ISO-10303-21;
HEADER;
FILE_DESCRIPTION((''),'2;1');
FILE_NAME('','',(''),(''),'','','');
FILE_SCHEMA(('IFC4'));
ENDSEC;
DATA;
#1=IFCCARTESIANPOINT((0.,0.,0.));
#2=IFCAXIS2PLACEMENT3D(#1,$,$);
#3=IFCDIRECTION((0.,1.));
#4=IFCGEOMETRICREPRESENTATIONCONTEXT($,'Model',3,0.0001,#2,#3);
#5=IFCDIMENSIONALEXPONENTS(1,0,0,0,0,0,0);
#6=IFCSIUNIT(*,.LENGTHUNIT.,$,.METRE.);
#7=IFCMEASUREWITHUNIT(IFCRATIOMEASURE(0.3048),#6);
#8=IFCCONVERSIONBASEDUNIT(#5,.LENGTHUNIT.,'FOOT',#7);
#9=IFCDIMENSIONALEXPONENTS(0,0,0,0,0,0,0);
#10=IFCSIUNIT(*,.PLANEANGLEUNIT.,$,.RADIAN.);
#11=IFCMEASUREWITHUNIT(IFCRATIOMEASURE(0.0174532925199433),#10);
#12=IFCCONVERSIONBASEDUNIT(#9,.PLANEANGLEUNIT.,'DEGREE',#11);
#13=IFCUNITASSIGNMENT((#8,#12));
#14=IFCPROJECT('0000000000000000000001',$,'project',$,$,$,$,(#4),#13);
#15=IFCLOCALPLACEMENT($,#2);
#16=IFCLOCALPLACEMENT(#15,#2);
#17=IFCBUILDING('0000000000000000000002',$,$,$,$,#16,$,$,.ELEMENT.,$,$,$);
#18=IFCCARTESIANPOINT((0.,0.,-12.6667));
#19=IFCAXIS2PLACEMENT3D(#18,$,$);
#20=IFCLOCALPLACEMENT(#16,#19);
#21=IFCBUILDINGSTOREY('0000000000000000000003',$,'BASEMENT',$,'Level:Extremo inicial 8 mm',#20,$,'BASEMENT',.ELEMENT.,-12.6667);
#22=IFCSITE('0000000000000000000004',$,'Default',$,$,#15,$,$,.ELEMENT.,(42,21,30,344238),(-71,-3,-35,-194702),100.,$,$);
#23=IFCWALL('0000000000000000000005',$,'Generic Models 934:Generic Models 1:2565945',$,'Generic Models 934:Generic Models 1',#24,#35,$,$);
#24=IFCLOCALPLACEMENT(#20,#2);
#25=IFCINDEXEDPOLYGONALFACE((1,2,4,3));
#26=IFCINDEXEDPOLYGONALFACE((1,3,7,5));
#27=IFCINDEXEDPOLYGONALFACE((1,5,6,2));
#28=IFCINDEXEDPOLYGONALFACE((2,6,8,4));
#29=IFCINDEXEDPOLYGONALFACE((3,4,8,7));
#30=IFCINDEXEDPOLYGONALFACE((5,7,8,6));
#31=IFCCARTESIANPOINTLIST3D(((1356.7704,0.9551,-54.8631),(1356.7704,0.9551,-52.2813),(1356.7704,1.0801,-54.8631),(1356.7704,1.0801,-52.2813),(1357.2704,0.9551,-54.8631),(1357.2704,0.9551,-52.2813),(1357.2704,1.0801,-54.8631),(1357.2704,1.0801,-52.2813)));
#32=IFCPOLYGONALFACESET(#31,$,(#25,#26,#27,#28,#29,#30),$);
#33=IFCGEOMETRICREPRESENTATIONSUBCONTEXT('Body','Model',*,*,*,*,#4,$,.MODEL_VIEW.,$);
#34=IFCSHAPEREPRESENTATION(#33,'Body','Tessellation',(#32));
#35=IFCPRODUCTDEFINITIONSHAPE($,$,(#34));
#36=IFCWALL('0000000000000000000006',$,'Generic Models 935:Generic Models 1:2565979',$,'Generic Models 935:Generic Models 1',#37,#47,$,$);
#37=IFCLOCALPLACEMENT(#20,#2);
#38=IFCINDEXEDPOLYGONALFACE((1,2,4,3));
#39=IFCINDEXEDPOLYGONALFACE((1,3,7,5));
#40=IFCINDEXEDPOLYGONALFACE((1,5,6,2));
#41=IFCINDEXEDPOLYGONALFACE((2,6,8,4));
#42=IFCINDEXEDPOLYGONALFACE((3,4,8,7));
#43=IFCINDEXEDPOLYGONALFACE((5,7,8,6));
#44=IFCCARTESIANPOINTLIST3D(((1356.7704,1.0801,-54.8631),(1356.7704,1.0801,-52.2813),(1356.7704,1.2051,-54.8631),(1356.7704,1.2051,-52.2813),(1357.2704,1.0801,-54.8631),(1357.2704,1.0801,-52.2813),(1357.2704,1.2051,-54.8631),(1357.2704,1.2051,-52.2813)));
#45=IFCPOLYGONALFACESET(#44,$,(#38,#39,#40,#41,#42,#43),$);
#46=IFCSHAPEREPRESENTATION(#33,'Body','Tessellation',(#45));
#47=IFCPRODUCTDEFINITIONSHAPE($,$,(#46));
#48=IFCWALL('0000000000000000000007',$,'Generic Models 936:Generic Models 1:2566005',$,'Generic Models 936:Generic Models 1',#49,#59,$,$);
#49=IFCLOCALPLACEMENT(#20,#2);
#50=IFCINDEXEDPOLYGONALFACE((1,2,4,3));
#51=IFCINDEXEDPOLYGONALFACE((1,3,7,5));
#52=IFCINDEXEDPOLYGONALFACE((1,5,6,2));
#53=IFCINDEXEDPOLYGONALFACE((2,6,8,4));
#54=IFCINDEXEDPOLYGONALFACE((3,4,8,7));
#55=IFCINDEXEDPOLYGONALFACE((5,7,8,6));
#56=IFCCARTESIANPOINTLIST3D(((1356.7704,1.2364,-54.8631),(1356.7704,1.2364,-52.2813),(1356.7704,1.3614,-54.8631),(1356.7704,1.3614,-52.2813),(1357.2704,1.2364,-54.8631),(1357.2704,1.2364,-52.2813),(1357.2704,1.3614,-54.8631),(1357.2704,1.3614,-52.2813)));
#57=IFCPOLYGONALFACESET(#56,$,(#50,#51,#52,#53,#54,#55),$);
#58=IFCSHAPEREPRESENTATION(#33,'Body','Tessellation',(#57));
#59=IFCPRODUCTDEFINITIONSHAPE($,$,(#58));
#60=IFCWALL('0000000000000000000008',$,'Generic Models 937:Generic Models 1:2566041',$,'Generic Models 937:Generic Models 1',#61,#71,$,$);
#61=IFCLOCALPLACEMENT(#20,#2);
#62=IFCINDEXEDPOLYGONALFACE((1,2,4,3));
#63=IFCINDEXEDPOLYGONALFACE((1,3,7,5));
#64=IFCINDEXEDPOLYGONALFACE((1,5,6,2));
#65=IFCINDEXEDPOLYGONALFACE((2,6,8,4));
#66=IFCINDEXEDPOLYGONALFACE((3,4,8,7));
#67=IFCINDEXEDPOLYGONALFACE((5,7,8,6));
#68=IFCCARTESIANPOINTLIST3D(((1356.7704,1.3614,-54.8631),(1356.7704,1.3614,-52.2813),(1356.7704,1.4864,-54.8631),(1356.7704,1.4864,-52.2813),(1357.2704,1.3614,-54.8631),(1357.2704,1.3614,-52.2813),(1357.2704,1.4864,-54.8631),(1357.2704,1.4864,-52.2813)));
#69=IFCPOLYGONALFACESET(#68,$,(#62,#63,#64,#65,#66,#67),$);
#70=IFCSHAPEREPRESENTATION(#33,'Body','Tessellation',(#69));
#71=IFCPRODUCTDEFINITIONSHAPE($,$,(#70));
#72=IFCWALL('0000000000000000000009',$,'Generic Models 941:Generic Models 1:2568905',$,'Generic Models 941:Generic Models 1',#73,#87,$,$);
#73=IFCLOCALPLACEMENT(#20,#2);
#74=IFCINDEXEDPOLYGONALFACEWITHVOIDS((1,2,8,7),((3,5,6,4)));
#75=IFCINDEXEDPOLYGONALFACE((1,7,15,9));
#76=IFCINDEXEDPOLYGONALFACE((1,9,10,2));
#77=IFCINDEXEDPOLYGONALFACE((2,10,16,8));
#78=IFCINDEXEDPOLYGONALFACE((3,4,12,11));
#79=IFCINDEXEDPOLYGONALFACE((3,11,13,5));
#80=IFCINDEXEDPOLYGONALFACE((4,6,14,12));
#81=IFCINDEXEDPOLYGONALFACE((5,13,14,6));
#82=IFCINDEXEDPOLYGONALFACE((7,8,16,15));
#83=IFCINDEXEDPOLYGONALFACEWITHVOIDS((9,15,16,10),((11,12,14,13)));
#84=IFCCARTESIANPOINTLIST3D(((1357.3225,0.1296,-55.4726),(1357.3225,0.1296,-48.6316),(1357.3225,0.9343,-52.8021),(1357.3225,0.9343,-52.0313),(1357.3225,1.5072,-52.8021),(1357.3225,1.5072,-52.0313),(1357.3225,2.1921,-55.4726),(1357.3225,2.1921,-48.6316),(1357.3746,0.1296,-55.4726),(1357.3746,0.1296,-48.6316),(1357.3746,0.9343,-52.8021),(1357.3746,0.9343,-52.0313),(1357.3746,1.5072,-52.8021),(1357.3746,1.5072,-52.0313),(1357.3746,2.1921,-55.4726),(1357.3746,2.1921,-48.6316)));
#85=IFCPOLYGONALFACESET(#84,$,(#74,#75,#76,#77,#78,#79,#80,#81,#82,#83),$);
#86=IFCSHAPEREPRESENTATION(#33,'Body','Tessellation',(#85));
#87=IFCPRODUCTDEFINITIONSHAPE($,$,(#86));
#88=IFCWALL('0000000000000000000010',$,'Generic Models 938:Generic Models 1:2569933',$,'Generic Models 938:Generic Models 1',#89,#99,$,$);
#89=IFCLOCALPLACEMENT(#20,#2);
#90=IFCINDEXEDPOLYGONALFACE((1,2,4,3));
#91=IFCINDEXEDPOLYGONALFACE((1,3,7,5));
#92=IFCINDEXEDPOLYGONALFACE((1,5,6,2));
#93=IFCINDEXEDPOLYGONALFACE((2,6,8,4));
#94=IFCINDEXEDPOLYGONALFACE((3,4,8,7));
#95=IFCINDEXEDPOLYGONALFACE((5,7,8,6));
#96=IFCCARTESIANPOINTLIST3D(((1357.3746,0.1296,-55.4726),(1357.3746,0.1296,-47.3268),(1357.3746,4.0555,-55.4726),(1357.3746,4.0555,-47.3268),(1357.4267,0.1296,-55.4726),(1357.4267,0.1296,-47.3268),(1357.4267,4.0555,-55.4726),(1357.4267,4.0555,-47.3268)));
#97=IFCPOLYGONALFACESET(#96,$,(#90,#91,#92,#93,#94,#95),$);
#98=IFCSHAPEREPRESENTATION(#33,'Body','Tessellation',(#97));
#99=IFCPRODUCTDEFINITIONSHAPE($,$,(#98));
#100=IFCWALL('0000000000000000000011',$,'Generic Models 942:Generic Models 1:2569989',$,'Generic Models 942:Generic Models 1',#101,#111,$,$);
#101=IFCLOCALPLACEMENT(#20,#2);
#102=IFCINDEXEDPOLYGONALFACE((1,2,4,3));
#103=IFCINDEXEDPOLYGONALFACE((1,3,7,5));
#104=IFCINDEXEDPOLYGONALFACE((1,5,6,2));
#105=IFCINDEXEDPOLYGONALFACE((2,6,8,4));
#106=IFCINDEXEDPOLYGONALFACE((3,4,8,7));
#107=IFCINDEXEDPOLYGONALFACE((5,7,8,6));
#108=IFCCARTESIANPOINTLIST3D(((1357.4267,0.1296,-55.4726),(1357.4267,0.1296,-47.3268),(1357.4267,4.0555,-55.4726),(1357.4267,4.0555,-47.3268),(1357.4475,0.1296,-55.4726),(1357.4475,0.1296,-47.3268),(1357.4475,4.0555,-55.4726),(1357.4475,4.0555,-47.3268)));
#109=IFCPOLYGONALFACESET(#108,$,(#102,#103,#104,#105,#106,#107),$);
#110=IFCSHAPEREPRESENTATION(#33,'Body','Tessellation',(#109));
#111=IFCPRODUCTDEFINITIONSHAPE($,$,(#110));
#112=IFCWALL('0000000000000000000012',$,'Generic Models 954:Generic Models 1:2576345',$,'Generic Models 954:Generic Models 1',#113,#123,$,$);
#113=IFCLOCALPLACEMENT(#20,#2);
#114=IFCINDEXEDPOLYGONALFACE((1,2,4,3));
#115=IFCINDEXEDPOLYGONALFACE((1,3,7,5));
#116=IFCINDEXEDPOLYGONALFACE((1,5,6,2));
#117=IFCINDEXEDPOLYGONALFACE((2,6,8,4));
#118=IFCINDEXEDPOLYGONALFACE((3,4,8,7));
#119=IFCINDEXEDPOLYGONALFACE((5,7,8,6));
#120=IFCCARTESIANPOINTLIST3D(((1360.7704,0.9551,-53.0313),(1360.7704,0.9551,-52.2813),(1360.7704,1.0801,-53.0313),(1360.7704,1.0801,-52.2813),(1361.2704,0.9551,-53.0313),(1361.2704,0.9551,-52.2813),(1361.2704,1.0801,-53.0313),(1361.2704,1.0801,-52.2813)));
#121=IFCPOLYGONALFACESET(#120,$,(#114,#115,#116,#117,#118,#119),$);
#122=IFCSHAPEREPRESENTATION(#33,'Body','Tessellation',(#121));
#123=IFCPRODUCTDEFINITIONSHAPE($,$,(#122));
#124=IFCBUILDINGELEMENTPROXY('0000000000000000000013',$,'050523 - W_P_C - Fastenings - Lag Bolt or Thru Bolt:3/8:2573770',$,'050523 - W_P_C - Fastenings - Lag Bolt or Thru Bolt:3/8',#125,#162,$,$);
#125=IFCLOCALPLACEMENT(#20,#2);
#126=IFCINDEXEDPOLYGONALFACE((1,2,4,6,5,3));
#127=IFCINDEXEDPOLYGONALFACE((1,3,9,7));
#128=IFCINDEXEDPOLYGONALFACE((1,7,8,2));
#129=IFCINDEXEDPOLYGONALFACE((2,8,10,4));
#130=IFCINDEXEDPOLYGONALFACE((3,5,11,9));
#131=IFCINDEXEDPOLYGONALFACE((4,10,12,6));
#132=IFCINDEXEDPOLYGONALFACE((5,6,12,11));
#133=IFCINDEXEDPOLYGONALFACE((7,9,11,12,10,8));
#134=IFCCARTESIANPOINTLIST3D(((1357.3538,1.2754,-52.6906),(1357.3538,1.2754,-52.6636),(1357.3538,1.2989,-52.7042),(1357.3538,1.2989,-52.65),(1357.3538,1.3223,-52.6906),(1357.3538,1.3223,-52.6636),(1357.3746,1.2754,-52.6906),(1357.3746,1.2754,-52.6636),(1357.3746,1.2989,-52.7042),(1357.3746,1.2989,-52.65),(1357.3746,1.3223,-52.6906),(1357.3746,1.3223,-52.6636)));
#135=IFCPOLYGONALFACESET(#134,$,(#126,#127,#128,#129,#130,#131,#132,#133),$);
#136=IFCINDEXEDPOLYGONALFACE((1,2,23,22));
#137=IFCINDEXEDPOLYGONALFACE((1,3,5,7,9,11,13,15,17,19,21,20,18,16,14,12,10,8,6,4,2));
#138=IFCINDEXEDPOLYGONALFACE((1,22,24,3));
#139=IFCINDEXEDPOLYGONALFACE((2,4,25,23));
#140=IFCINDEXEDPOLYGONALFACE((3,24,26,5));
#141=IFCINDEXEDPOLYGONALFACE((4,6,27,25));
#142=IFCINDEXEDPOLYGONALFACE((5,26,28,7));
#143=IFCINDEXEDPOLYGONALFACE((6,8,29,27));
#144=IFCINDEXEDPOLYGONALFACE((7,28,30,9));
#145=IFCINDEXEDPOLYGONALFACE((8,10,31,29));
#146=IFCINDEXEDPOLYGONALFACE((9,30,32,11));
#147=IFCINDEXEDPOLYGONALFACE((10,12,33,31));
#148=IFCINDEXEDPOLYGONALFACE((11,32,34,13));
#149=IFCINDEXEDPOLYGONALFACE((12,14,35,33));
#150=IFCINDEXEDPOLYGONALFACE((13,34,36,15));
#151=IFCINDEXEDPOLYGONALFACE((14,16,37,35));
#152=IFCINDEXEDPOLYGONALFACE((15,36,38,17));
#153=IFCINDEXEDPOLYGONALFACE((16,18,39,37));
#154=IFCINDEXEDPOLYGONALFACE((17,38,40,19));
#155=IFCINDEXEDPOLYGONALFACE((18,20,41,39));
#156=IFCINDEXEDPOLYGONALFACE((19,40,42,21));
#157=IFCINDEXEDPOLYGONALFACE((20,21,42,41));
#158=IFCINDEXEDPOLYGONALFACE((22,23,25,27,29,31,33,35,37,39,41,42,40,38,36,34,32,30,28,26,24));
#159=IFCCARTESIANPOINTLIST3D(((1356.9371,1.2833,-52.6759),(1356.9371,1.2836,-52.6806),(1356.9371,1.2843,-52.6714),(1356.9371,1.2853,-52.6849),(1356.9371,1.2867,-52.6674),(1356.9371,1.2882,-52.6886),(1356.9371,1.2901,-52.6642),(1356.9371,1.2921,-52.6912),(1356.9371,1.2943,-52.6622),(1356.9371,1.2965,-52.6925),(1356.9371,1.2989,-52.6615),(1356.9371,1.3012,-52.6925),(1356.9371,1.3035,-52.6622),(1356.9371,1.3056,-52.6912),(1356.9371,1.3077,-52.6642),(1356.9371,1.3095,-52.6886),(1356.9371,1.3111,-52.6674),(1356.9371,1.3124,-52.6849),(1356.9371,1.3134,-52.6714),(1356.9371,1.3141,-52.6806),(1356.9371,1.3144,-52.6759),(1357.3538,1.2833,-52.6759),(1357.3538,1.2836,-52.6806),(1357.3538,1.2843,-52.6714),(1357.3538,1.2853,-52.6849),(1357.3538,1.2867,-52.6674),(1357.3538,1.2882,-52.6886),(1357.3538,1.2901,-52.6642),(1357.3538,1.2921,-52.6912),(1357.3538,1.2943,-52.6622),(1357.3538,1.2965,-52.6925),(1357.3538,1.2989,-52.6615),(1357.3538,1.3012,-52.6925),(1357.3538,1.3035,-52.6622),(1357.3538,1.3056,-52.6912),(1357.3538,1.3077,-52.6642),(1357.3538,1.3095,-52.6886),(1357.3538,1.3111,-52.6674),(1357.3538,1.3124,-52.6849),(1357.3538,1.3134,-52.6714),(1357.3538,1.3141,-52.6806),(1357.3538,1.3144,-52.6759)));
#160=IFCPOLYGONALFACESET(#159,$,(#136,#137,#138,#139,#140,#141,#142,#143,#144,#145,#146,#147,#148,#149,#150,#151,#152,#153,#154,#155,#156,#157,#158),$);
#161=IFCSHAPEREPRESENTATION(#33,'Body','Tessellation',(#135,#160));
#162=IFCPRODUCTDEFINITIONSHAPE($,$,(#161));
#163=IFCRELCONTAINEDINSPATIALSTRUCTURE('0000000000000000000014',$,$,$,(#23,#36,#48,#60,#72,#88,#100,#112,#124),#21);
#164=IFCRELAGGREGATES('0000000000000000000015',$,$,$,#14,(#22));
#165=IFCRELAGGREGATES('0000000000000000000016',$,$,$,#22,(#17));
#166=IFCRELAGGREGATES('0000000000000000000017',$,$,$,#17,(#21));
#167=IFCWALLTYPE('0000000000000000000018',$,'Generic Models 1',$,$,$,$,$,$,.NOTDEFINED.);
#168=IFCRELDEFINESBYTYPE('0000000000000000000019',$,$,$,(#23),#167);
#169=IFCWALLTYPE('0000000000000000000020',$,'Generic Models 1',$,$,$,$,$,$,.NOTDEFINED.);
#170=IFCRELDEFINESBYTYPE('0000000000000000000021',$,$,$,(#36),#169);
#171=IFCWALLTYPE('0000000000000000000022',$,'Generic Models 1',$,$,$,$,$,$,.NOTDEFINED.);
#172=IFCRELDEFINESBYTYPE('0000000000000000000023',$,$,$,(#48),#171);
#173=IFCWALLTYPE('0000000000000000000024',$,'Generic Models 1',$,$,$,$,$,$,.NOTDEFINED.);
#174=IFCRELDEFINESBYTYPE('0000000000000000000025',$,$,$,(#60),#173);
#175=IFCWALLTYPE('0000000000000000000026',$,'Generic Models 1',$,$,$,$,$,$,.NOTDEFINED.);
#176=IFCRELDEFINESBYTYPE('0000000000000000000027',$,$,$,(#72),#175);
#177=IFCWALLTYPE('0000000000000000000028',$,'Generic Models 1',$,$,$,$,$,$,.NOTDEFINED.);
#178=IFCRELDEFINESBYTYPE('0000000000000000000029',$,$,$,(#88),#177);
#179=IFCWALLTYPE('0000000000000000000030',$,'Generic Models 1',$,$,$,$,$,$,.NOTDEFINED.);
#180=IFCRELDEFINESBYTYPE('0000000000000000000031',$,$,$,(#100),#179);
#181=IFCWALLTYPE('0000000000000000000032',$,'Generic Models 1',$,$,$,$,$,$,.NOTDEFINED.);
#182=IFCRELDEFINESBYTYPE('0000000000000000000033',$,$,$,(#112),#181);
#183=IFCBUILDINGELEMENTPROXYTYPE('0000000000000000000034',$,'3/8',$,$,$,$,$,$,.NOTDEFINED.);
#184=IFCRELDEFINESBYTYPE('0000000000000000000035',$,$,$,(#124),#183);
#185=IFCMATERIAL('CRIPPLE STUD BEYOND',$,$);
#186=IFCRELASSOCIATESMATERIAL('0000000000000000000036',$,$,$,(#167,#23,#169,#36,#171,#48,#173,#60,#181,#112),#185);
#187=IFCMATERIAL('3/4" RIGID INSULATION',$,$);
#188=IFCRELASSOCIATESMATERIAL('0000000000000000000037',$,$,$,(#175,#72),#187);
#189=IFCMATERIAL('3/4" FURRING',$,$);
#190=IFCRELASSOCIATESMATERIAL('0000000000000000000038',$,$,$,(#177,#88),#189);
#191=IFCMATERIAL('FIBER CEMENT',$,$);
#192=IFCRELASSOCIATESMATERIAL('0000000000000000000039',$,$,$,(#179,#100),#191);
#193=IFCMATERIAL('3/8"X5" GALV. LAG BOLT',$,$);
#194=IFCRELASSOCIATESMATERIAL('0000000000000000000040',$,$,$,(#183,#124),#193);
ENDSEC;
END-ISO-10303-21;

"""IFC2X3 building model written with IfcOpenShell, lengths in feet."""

from ifc_helpers import new_model, entity, si_unit, converted_unit, direction, frame, frame_2d, origin, origin_2d_with_axis, place, context, subcontext, project, spatial, polyline, rectangle, circle, outline, extrude, source, transform, mapped, material, type_object, type_shapes, element, save


model = new_model("IFC2X3")

# Units and contexts
model_context = context("Model", 3, precision=0.0001, world=origin(), true_north=direction((0.0, 1.0)))
body_context = subcontext(model_context, "Body", "Model", "MODEL_VIEW")
ifc_project = project(units=[converted_unit("LENGTHUNIT", "FOOT", entity("IfcRatioMeasure", 0.3048), si_unit("LENGTHUNIT", "METRE"), dimensions=[1, 0, 0, 0, 0, 0, 0]), converted_unit("PLANEANGLEUNIT", "DEGREE", entity("IfcRatioMeasure", 0.0174532925199433), si_unit("PLANEANGLEUNIT", "RADIAN"), dimensions=[0, 0, 0, 0, 0, 0, 0])], contexts=[model_context])

# Site, building, storey
site_placement = place(None, origin())
site = spatial("IfcSite", under=ifc_project, at=site_placement, Name="Default", CompositionType="ELEMENT", RefLatitude=(42, 21, 30, 344238), RefLongitude=(-71, -3, -35, -194702), RefElevation=100.0)
building_placement = place(site_placement, origin())
building = spatial("IfcBuilding", under=site, at=building_placement, CompositionType="ELEMENT")
storey_placement = place(building_placement, frame((0.0, 0.0, -12.6667)))
storey = spatial("IfcBuildingStorey", under=building, at=storey_placement, Name="BASEMENT", ObjectType="Level:Extremo inicial 8 mm", LongName="BASEMENT", CompositionType="ELEMENT", Elevation=-12.6667)

# Walls
ifc_material_1 = material(Name="CRIPPLE STUD BEYOND")
wall_type_1 = type_object("IfcWallType", Name="Generic Models 1", PredefinedType="NOTDEFINED", material=ifc_material_1)
wall_1_placement = place(storey_placement, frame((1356.7704, 0.9551, -54.8631)))
element("IfcWall", 1, at=wall_1_placement, inside=storey, type_object=wall_type_1, material=ifc_material_1, Name="Generic Models 934:Generic Models 1:2565945", ObjectType="Generic Models 934:Generic Models 1", context=body_context, shape_type="SweptSolid", body=[
    extrude(rectangle(XDim=0.125, YDim=0.5, at=origin_2d_with_axis()), frame((0.25, 0.0625, 0.0), z_axis=(0.0, 0.0, 1.0), x_axis=(0.0, 1.0, 0.0)), (0.0, 0.0, 1.0), 2.5819),
])
wall_type_2 = type_object("IfcWallType", Name="Generic Models 1", PredefinedType="NOTDEFINED", material=ifc_material_1)
wall_2_placement = place(storey_placement, frame((1356.7704, 1.0801, -54.8631)))
element("IfcWall", 2, at=wall_2_placement, inside=storey, type_object=wall_type_2, material=ifc_material_1, Name="Generic Models 935:Generic Models 1:2565979", ObjectType="Generic Models 935:Generic Models 1", context=body_context, shape_type="SweptSolid", body=[
    extrude(rectangle(XDim=0.125, YDim=0.5, at=origin_2d_with_axis()), frame((0.25, 0.0625, 0.0), z_axis=(0.0, 0.0, 1.0), x_axis=(0.0, 1.0, 0.0)), (0.0, 0.0, 1.0), 2.5819),
])
wall_type_3 = type_object("IfcWallType", Name="Generic Models 1", PredefinedType="NOTDEFINED", material=ifc_material_1)
wall_3_placement = place(storey_placement, frame((1356.7704, 1.2364, -54.8631)))
element("IfcWall", 3, at=wall_3_placement, inside=storey, type_object=wall_type_3, material=ifc_material_1, Name="Generic Models 936:Generic Models 1:2566005", ObjectType="Generic Models 936:Generic Models 1", context=body_context, shape_type="SweptSolid", body=[
    extrude(rectangle(XDim=0.125, YDim=0.5, at=origin_2d_with_axis()), frame((0.25, 0.0625, 0.0), z_axis=(0.0, 0.0, 1.0), x_axis=(0.0, 1.0, 0.0)), (0.0, 0.0, 1.0), 2.5819),
])
wall_type_4 = type_object("IfcWallType", Name="Generic Models 1", PredefinedType="NOTDEFINED", material=ifc_material_1)
wall_4_placement = place(storey_placement, frame((1356.7704, 1.3614, -54.8631)))
element("IfcWall", 4, at=wall_4_placement, inside=storey, type_object=wall_type_4, material=ifc_material_1, Name="Generic Models 937:Generic Models 1:2566041", ObjectType="Generic Models 937:Generic Models 1", context=body_context, shape_type="SweptSolid", body=[
    extrude(rectangle(XDim=0.125, YDim=0.5, at=origin_2d_with_axis()), frame((0.25, 0.0625, 0.0), z_axis=(0.0, 0.0, 1.0), x_axis=(0.0, 1.0, 0.0)), (0.0, 0.0, 1.0), 2.5819),
])

# Wall, opening
ifc_material_2 = material(Name="3/4\" RIGID INSULATION")
wall_type_5 = type_object("IfcWallType", Name="Generic Models 1", PredefinedType="NOTDEFINED", material=ifc_material_2)
wall_5_placement = place(storey_placement, frame((1357.3225, 0.1296, -55.4726), z_axis=(0.0, 0.0, 1.0), x_axis=(0.0, 1.0, 0.0)))
wall_5 = element("IfcWall", 5, at=wall_5_placement, inside=storey, type_object=wall_type_5, material=ifc_material_2, Name="Generic Models 941:Generic Models 1:2568905", ObjectType="Generic Models 941:Generic Models 1", context=body_context, shape_type="SweptSolid", body=[
    extrude(rectangle(XDim=0.0521, YDim=2.0625, at=origin_2d_with_axis()), frame((1.0313, -0.026, 0.0), z_axis=(0.0, 0.0, 1.0), x_axis=(0.0, 1.0, 0.0)), (0.0, 0.0, 1.0), 6.841),
])
opening_1_placement = place(storey_placement, frame((1357.3225, 0.1296, -55.4726), z_axis=(0.0, 0.0, 1.0), x_axis=(0.0, 1.0, 0.0)))
element("IfcOpeningElement", 6, at=opening_1_placement, cuts=wall_5, ObjectType="Opening", context=body_context, shape_type="SweptSolid", body=[
    extrude(rectangle(XDim=0.7708, YDim=0.5729, at=frame_2d((0.0, 0.0), x_axis=(0.0, 1.0))), frame((1.0911, -0.0521, 3.0559), z_axis=(0.0, 1.0, 0.0), x_axis=(-1.0, 0.0, 0.0)), (0.0, 0.0, 1.0), 0.0521),
])

# Walls
ifc_material_3 = material(Name="3/4\" FURRING")
wall_type_6 = type_object("IfcWallType", Name="Generic Models 1", PredefinedType="NOTDEFINED", material=ifc_material_3)
wall_6_placement = place(storey_placement, frame((1357.3746, 0.1296, -55.4726), z_axis=(0.0, 0.0, 1.0), x_axis=(0.0, 1.0, 0.0)))
element("IfcWall", 7, at=wall_6_placement, inside=storey, type_object=wall_type_6, material=ifc_material_3, Name="Generic Models 938:Generic Models 1:2569933", ObjectType="Generic Models 938:Generic Models 1", context=body_context, shape_type="SweptSolid", body=[
    extrude(rectangle(XDim=3.9258, YDim=0.0521, at=frame_2d((0.0, 0.0), x_axis=(1.0, 0.0))), frame((1.9629, -0.026, 0.0)), (0.0, 0.0, 1.0), 8.1457),
])
ifc_material_4 = material(Name="FIBER CEMENT")
wall_type_7 = type_object("IfcWallType", Name="Generic Models 1", PredefinedType="NOTDEFINED", material=ifc_material_4)
wall_7_placement = place(storey_placement, frame((1357.4267, 0.1296, -55.4726), z_axis=(0.0, 0.0, 1.0), x_axis=(0.0, 1.0, 0.0)))
element("IfcWall", 8, at=wall_7_placement, inside=storey, type_object=wall_type_7, material=ifc_material_4, Name="Generic Models 942:Generic Models 1:2569989", ObjectType="Generic Models 942:Generic Models 1", context=body_context, shape_type="SweptSolid", body=[
    extrude(rectangle(XDim=3.9258, YDim=0.0208, at=frame_2d((0.0, 0.0), x_axis=(1.0, 0.0))), frame((1.9629, -0.0104, 0.0)), (0.0, 0.0, 1.0), 8.1457),
])
wall_type_8 = type_object("IfcWallType", Name="Generic Models 1", PredefinedType="NOTDEFINED", material=ifc_material_1)
wall_8_placement = place(storey_placement, frame((1360.7704, 0.9551, -53.0313)))
element("IfcWall", 9, at=wall_8_placement, inside=storey, type_object=wall_type_8, material=ifc_material_1, Name="Generic Models 954:Generic Models 1:2576345", ObjectType="Generic Models 954:Generic Models 1", context=body_context, shape_type="SweptSolid", body=[
    extrude(rectangle(XDim=0.125, YDim=0.5, at=frame_2d((0.0, 0.0), x_axis=(1.0, 0.0))), frame((0.25, 0.0625, 0.0), z_axis=(0.0, 0.0, 1.0), x_axis=(0.0, 1.0, 0.0)), (0.0, 0.0, 1.0), 0.75),
])

# Building element proxy
ifc_material_5 = material(Name="3/8\"X5\" GALV. LAG BOLT")
building_element_proxy_type = type_object("IfcBuildingElementProxyType", Name="3/8", PredefinedType="NOTDEFINED", material=ifc_material_5)
shared_shape = source(origin(), body_context, "Body", "SweptSolid", [
    extrude(outline(polyline([(-0.0135, -0.0234), (0.0135, -0.0234), (0.0271, 0.0), (0.0135, 0.0234), (-0.0135, 0.0234), (-0.0271, 0.0), (-0.0135, -0.0234)])), frame((0.0, 0.0, 0.0), z_axis=(0.0, 0.0, 1.0), x_axis=(0.0, -1.0, 0.0)), (0.0, 0.0, 1.0), 0.0208),
    extrude(circle(Radius=0.0156, at=frame_2d((0.0, 0.0), x_axis=(1.0, 0.0))), frame((0.0, 0.0, -0.4167), z_axis=(0.0, 0.0, 1.0), x_axis=(0.0, 1.0, 0.0)), (0.0, 0.0, 1.0), 0.4167),
])
type_shapes(building_element_proxy_type, [shared_shape])
for number, where, z_axis, x_axis, name in (
    (10, (1357.3538, 1.2989, -52.6771), (1.0, 0.0, 0.0), (0.0, 1.0, 0.0), "050523 - W_P_C - Fastenings - Lag Bolt or Thru Bolt:3/8:2573770"),
):
    element("IfcBuildingElementProxy", number, at=place(storey_placement, frame(where, z_axis=z_axis, x_axis=x_axis)), inside=storey, type_object=building_element_proxy_type, material=ifc_material_5, Name=name, ObjectType="050523 - W_P_C - Fastenings - Lag Bolt or Thru Bolt:3/8", context=body_context, shape_type="MappedRepresentation", body=[
        mapped(shared_shape, transform((0.0, 0.0, 0.0), scale=1.0)),
    ])

save(model, "model.ifc")
